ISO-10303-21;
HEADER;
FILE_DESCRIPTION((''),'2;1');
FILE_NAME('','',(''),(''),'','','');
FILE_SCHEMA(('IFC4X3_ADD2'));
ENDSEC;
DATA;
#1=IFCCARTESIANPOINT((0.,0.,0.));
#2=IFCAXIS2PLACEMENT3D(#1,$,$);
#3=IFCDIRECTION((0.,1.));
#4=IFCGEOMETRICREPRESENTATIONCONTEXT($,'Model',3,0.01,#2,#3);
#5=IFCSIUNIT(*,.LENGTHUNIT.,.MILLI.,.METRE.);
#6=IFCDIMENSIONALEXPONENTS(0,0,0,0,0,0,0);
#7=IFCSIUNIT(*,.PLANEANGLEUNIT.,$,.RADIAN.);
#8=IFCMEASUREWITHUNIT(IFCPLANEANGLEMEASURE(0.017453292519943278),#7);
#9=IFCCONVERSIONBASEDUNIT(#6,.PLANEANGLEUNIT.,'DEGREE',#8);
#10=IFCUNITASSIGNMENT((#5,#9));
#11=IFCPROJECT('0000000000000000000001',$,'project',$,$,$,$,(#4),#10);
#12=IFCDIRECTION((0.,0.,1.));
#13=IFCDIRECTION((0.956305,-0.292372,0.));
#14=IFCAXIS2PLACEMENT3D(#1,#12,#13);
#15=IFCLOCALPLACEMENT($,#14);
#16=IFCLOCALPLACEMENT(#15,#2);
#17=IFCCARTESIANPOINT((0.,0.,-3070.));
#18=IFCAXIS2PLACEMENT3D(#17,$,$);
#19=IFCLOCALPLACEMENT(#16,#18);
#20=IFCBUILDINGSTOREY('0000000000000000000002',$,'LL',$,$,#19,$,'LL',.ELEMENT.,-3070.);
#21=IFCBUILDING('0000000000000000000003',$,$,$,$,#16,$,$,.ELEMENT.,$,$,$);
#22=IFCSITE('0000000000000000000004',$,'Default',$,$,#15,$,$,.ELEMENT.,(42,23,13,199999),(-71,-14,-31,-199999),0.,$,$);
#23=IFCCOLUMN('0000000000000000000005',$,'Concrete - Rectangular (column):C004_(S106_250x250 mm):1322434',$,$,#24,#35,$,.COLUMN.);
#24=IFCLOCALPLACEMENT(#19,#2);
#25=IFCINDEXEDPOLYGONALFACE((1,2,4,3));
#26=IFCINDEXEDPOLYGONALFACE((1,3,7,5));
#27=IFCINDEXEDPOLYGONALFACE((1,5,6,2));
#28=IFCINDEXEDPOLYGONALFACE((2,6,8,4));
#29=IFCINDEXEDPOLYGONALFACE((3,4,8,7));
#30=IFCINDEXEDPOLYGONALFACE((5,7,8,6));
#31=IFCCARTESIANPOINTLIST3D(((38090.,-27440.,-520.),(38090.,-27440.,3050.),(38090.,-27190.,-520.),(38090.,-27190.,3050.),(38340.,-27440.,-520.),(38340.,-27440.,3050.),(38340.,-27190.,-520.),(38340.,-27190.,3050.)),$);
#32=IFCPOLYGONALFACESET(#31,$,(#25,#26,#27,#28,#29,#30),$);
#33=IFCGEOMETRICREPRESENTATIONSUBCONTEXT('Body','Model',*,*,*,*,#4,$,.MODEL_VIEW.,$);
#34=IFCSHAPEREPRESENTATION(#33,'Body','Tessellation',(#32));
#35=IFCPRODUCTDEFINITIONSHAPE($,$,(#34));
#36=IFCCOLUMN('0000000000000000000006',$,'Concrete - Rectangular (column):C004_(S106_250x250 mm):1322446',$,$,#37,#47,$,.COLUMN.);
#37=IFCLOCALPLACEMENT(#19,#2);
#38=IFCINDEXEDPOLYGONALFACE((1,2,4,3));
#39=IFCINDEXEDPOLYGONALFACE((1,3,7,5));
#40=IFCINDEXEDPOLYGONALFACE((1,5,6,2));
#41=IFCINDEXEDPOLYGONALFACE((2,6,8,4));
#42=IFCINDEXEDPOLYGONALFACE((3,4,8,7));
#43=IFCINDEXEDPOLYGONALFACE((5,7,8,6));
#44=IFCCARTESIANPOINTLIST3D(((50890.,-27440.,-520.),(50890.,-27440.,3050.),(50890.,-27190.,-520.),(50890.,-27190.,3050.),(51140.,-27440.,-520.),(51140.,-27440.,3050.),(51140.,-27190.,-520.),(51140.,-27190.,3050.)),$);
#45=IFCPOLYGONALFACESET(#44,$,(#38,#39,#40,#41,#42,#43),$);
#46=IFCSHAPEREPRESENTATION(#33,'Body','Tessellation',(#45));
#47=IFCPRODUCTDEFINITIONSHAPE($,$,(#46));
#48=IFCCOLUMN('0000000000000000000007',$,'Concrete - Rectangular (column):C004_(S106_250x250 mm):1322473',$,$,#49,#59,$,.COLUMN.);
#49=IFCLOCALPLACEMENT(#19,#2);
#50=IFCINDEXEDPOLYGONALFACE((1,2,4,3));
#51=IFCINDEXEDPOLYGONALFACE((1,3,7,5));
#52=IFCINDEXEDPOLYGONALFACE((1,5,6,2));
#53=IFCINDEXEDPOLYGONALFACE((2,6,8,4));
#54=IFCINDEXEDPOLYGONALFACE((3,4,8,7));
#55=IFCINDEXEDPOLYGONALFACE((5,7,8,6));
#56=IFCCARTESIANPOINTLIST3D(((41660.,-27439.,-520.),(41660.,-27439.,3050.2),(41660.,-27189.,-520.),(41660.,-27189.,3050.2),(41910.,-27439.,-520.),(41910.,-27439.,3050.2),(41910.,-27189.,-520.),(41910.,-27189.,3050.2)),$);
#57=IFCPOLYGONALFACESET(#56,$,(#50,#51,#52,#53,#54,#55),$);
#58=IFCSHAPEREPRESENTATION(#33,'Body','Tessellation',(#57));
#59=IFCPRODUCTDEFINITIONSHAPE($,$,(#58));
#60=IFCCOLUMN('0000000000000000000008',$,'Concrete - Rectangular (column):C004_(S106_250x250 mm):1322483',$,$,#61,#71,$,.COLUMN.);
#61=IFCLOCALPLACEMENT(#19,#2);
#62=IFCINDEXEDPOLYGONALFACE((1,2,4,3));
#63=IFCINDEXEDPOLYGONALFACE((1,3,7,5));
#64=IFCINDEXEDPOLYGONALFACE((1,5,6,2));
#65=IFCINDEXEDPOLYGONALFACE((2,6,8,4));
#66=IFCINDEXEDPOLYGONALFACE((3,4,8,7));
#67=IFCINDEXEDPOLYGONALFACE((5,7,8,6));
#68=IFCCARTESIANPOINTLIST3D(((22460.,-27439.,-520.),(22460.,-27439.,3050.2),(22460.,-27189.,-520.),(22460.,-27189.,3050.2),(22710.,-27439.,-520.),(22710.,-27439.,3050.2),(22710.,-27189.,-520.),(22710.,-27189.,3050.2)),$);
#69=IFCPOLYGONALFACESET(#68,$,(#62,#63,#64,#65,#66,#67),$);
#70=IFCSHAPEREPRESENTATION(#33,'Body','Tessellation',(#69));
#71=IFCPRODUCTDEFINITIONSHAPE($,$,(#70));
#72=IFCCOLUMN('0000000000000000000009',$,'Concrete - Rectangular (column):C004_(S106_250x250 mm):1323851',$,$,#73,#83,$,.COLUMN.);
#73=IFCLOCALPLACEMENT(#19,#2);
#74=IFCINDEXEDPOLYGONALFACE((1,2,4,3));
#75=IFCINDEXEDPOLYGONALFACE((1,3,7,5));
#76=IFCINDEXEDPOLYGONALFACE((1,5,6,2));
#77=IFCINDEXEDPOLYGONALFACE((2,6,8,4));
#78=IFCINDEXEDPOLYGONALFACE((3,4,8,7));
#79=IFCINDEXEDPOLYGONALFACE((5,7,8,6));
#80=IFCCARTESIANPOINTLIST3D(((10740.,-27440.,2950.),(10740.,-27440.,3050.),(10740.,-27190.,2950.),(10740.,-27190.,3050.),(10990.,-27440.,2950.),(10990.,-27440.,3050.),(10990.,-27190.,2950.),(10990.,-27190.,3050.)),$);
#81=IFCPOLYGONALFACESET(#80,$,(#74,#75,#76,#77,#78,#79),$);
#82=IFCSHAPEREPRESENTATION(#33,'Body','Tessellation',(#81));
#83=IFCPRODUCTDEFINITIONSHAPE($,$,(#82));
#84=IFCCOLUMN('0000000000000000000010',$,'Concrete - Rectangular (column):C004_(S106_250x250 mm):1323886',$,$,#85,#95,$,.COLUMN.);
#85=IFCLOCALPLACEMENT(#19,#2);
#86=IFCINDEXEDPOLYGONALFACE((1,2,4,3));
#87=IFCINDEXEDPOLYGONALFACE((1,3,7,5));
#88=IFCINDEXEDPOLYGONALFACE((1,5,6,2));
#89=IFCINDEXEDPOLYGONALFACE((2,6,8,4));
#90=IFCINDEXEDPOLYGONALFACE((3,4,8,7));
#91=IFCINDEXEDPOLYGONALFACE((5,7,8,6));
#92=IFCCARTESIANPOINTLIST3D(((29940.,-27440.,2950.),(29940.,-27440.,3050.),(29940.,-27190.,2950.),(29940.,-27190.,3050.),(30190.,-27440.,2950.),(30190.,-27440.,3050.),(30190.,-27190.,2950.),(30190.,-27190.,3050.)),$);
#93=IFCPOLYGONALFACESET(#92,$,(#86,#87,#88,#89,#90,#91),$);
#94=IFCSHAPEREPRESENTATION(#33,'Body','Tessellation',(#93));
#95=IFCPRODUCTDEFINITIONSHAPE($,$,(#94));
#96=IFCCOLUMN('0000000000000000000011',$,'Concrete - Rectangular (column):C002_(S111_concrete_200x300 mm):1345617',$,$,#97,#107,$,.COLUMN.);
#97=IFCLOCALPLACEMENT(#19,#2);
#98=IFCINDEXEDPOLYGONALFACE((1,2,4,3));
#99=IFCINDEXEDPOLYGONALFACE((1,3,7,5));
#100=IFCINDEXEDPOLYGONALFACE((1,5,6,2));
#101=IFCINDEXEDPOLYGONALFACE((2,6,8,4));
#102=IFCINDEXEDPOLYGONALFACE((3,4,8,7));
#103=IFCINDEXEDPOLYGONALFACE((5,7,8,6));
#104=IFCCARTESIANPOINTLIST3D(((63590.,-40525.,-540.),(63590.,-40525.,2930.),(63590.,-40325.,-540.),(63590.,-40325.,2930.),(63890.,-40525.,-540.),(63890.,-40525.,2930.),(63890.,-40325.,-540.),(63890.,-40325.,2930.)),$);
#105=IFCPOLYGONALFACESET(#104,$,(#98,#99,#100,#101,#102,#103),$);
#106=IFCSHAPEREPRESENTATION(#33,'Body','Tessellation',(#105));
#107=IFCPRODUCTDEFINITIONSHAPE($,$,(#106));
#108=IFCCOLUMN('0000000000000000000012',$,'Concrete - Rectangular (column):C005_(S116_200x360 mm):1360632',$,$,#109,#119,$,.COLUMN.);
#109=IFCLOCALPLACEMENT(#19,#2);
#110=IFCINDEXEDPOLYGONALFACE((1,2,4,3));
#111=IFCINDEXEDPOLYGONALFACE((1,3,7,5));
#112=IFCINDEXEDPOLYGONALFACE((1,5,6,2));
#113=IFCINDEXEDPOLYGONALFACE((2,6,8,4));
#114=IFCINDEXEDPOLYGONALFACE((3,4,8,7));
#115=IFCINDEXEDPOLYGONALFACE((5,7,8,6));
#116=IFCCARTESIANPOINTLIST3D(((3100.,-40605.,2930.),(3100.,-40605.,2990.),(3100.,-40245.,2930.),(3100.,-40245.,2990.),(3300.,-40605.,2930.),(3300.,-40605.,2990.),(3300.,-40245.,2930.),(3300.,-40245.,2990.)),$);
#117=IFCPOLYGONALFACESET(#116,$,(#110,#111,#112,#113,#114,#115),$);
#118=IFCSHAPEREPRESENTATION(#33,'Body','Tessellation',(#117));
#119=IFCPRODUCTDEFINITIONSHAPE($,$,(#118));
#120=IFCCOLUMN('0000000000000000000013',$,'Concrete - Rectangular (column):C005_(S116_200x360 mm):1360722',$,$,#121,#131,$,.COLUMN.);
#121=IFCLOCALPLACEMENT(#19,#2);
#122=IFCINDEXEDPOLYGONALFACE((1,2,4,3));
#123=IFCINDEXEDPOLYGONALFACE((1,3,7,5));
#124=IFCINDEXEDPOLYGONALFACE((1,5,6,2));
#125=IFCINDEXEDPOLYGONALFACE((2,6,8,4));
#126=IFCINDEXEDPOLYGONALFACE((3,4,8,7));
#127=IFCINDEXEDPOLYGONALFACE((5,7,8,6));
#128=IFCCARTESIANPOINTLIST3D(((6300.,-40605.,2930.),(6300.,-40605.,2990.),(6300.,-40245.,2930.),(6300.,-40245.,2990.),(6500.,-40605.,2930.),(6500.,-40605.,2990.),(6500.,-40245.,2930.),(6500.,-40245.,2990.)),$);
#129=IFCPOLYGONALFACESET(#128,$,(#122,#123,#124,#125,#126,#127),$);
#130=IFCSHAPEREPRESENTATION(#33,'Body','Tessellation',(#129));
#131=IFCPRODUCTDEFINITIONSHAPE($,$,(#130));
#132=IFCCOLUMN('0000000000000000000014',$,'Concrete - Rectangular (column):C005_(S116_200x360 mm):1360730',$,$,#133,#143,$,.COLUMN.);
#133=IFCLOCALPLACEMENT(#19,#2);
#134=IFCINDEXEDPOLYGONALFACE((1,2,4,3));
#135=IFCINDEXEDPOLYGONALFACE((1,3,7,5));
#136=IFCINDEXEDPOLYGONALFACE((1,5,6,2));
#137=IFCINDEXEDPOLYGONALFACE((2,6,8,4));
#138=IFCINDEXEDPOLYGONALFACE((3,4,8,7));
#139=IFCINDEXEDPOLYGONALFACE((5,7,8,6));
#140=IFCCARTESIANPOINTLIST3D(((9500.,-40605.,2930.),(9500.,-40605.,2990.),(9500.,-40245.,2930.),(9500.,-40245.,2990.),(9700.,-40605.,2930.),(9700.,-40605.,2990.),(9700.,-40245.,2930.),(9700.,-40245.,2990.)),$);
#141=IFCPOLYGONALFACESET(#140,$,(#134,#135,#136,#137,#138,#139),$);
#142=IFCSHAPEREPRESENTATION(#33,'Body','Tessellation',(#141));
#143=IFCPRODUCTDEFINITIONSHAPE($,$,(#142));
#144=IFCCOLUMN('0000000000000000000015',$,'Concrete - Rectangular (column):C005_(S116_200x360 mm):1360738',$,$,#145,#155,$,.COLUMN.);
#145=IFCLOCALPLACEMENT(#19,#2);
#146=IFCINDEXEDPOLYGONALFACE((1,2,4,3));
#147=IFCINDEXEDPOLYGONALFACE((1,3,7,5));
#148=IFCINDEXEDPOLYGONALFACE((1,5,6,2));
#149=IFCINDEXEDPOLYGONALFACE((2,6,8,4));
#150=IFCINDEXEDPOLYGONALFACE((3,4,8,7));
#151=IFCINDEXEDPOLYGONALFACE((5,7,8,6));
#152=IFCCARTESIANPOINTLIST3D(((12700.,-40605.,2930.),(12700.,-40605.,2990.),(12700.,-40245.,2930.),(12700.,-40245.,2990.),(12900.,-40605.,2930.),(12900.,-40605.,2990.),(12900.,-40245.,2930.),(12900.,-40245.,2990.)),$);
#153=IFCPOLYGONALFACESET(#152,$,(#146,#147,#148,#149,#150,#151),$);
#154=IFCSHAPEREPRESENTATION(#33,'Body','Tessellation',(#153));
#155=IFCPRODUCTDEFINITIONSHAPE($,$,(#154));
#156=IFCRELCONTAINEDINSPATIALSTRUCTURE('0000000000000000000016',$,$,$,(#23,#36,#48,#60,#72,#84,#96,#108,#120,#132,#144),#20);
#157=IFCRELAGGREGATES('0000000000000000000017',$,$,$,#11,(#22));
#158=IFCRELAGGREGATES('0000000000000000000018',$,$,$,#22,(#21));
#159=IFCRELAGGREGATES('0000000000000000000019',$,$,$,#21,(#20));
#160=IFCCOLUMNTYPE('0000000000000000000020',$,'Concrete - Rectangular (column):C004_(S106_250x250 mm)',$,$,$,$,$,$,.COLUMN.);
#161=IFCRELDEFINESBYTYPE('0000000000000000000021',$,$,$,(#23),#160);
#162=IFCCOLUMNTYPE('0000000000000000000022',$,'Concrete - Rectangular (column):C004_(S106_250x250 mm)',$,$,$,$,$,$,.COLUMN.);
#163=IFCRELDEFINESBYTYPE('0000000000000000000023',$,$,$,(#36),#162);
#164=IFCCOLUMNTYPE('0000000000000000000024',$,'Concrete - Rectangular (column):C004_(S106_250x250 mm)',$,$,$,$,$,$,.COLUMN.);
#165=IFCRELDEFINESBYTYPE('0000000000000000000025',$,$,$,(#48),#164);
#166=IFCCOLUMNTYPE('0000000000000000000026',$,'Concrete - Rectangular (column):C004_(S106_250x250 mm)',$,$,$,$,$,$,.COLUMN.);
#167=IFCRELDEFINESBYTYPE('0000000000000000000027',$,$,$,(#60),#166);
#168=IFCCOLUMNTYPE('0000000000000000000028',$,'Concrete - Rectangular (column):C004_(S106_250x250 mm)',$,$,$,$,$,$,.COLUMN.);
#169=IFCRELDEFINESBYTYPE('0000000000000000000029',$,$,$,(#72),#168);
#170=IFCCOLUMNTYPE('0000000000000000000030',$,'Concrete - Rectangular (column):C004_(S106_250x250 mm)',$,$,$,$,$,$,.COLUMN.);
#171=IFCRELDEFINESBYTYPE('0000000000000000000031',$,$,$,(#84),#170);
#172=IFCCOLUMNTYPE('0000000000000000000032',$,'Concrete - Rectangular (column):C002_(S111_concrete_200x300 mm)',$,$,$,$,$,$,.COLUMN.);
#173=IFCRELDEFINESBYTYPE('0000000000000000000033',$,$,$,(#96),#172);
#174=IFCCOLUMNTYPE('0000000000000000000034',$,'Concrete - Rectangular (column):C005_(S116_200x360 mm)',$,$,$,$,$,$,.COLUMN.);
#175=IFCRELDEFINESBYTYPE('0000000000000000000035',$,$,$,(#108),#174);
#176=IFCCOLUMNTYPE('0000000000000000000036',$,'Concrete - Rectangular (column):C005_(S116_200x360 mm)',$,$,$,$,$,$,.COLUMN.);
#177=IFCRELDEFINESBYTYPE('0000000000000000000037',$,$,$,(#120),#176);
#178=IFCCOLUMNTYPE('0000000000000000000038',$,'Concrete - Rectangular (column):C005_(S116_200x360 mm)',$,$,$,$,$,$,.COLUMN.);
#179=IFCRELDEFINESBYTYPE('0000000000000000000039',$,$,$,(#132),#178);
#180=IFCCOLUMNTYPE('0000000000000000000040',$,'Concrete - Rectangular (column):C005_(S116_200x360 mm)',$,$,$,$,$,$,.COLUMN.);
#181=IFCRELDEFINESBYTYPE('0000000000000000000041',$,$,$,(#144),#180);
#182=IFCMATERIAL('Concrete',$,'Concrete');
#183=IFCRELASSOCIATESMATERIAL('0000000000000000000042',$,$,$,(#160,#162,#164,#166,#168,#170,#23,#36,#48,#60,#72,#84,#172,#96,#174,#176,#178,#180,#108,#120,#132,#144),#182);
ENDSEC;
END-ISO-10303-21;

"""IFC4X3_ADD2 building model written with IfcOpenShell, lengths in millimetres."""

from ifc_helpers import new_model, entity, si_unit, converted_unit, direction, frame, frame_2d, origin, place, context, subcontext, project, spatial, rectangle, extrude, source, transform, mapped, material, material_profile, profile_set, profile_usage, type_object, type_shapes, element, save


model = new_model("IFC4X3_ADD2")

# Units and contexts
model_context = context("Model", 3, precision=0.01, world=origin(), true_north=direction((0.0, 1.0)))
body_context = subcontext(model_context, "Body", "Model", "MODEL_VIEW")
ifc_project = project(units=[si_unit("LENGTHUNIT", "METRE", prefix="MILLI"), converted_unit("PLANEANGLEUNIT", "DEGREE", entity("IfcPlaneAngleMeasure", 0.017453292519943278), si_unit("PLANEANGLEUNIT", "RADIAN"), dimensions=[0, 0, 0, 0, 0, 0, 0])], contexts=[model_context])

# Site, building, storey
site_placement = place(None, frame((0.0, 0.0, 0.0), z_axis=(0.0, 0.0, 1.0), x_axis=(0.956305, -0.292372, 0.0)))
site = spatial("IfcSite", under=ifc_project, at=site_placement, Name="Default", CompositionType="ELEMENT", RefLatitude=(42, 23, 13, 199999), RefLongitude=(-71, -14, -31, -199999), RefElevation=0.0)
building_placement = place(site_placement, origin())
building = spatial("IfcBuilding", under=site, at=building_placement, CompositionType="ELEMENT")
storey_placement = place(building_placement, frame((0.0, 0.0, -3070.0)))
storey = spatial("IfcBuildingStorey", under=building, at=storey_placement, Name="LL", LongName="LL", CompositionType="ELEMENT", Elevation=-3070.0)

# Columns
ifc_material_1 = material(Name="Concrete", Category="Concrete")
ifc_material_profile_1 = material_profile(ifc_material_1, rectangle(XDim=300.0, YDim=200.0, at=frame_2d((0.0, 0.0), x_axis=(1.0, 0.0))), Name="C002_(S111_concrete_200x300 mm)")
ifc_profile_set_1 = profile_set([ifc_material_profile_1], Name="C002_(S111_concrete_200x300 mm)")
ifc_profile_usage_1 = profile_usage(ifc_profile_set_1)
ifc_material_profile_2 = material_profile(ifc_material_1, rectangle(XDim=250.0, YDim=250.0, at=frame_2d((0.0, 0.0), x_axis=(1.0, 0.0))), Name="C004_(S106_250x250 mm)")
ifc_profile_set_2 = profile_set([ifc_material_profile_2], Name="C004_(S106_250x250 mm)")
ifc_profile_usage_2 = profile_usage(ifc_profile_set_2)
column_type_1 = type_object("IfcColumnType", Name="Concrete - Rectangular (column):C004_(S106_250x250 mm)", PredefinedType="COLUMN", material=ifc_profile_set_2)
shared_shape_1 = source(origin(), body_context, "Body", "SweptSolid", [
    extrude(rectangle(XDim=250.0, YDim=250.0, at=frame_2d((0.0, 0.0), x_axis=(1.0, 0.0))), frame((38215.0, -27315.0, -3590.0), z_axis=(0.0, 0.0, 1.0), x_axis=(-1.0, 0.0, 0.0)), (0.0, 0.0, 1.0), 3570.0),
])
type_shapes(column_type_1, [shared_shape_1])
column_1_placement = place(storey_placement, frame((0.0, 0.0, 3070.0)))
element("IfcColumn", 1, at=column_1_placement, inside=storey, type_object=column_type_1, material=ifc_profile_usage_2, Name="Concrete - Rectangular (column):C004_(S106_250x250 mm):1322434", PredefinedType="COLUMN", context=body_context, shape_type="MappedRepresentation", body=[
    mapped(shared_shape_1, transform((0.0, 0.0, 0.0), scale=1.0)),
])
column_type_2 = type_object("IfcColumnType", Name="Concrete - Rectangular (column):C004_(S106_250x250 mm)", PredefinedType="COLUMN", material=ifc_profile_set_2)
shared_shape_2 = source(origin(), body_context, "Body", "SweptSolid", [
    extrude(rectangle(XDim=250.0, YDim=250.0, at=frame_2d((0.0, 0.0), x_axis=(1.0, 0.0))), frame((51015.0, -27315.0, -3590.0), z_axis=(0.0, 0.0, 1.0), x_axis=(-1.0, 0.0, 0.0)), (0.0, 0.0, 1.0), 3570.0),
])
type_shapes(column_type_2, [shared_shape_2])
column_2_placement = place(storey_placement, frame((0.0, 0.0, 3070.0)))
element("IfcColumn", 2, at=column_2_placement, inside=storey, type_object=column_type_2, material=ifc_profile_usage_2, Name="Concrete - Rectangular (column):C004_(S106_250x250 mm):1322446", PredefinedType="COLUMN", context=body_context, shape_type="MappedRepresentation", body=[
    mapped(shared_shape_2, transform((0.0, 0.0, 0.0), scale=1.0)),
])
column_type_3 = type_object("IfcColumnType", Name="Concrete - Rectangular (column):C004_(S106_250x250 mm)", PredefinedType="COLUMN", material=ifc_profile_set_2)
shared_shape_3 = source(origin(), body_context, "Body", "SweptSolid", [
    extrude(rectangle(XDim=250.0, YDim=250.0, at=frame_2d((0.0, 0.0), x_axis=(1.0, 0.0))), frame((41785.0, -27314.0, -3590.0), z_axis=(0.0, 0.0, 1.0), x_axis=(-1.0, 0.0, 0.0)), (0.0, 0.0, 1.0), 3570.2),
])
type_shapes(column_type_3, [shared_shape_3])
column_3_placement = place(storey_placement, frame((0.0, 0.0, 3070.0)))
element("IfcColumn", 3, at=column_3_placement, inside=storey, type_object=column_type_3, material=ifc_profile_usage_2, Name="Concrete - Rectangular (column):C004_(S106_250x250 mm):1322473", PredefinedType="COLUMN", context=body_context, shape_type="MappedRepresentation", body=[
    mapped(shared_shape_3, transform((0.0, 0.0, 0.0), scale=1.0)),
])
column_type_4 = type_object("IfcColumnType", Name="Concrete - Rectangular (column):C004_(S106_250x250 mm)", PredefinedType="COLUMN", material=ifc_profile_set_2)
shared_shape_4 = source(origin(), body_context, "Body", "SweptSolid", [
    extrude(rectangle(XDim=250.0, YDim=250.0, at=frame_2d((0.0, 0.0), x_axis=(1.0, 0.0))), frame((22585.0, -27314.0, -3590.0), z_axis=(0.0, 0.0, 1.0), x_axis=(-1.0, 0.0, 0.0)), (0.0, 0.0, 1.0), 3570.2),
])
type_shapes(column_type_4, [shared_shape_4])
column_4_placement = place(storey_placement, frame((0.0, 0.0, 3070.0)))
element("IfcColumn", 4, at=column_4_placement, inside=storey, type_object=column_type_4, material=ifc_profile_usage_2, Name="Concrete - Rectangular (column):C004_(S106_250x250 mm):1322483", PredefinedType="COLUMN", context=body_context, shape_type="MappedRepresentation", body=[
    mapped(shared_shape_4, transform((0.0, 0.0, 0.0), scale=1.0)),
])
column_type_5 = type_object("IfcColumnType", Name="Concrete - Rectangular (column):C004_(S106_250x250 mm)", PredefinedType="COLUMN", material=ifc_profile_set_2)
shared_shape_5 = source(origin(), body_context, "Body", "SweptSolid", [
    extrude(rectangle(XDim=250.0, YDim=250.0, at=frame_2d((0.0, 0.0), x_axis=(1.0, 0.0))), frame((10865.0, -27315.0, -120.0), z_axis=(0.0, 0.0, 1.0), x_axis=(-1.0, 0.0, 0.0)), (0.0, 0.0, 1.0), 100.0),
])
type_shapes(column_type_5, [shared_shape_5])
column_5_placement = place(storey_placement, frame((0.0, 0.0, 3070.0)))
element("IfcColumn", 5, at=column_5_placement, inside=storey, type_object=column_type_5, material=ifc_profile_usage_2, Name="Concrete - Rectangular (column):C004_(S106_250x250 mm):1323851", PredefinedType="COLUMN", context=body_context, shape_type="MappedRepresentation", body=[
    mapped(shared_shape_5, transform((0.0, 0.0, 0.0), scale=1.0)),
])
column_type_6 = type_object("IfcColumnType", Name="Concrete - Rectangular (column):C004_(S106_250x250 mm)", PredefinedType="COLUMN", material=ifc_profile_set_2)
shared_shape_6 = source(origin(), body_context, "Body", "SweptSolid", [
    extrude(rectangle(XDim=250.0, YDim=250.0, at=frame_2d((0.0, 0.0), x_axis=(1.0, 0.0))), frame((30065.0, -27315.0, -120.0), z_axis=(0.0, 0.0, 1.0), x_axis=(-1.0, 0.0, 0.0)), (0.0, 0.0, 1.0), 100.0),
])
type_shapes(column_type_6, [shared_shape_6])
column_6_placement = place(storey_placement, frame((0.0, 0.0, 3070.0)))
element("IfcColumn", 6, at=column_6_placement, inside=storey, type_object=column_type_6, material=ifc_profile_usage_2, Name="Concrete - Rectangular (column):C004_(S106_250x250 mm):1323886", PredefinedType="COLUMN", context=body_context, shape_type="MappedRepresentation", body=[
    mapped(shared_shape_6, transform((0.0, 0.0, 0.0), scale=1.0)),
])
column_type_7 = type_object("IfcColumnType", Name="Concrete - Rectangular (column):C002_(S111_concrete_200x300 mm)", PredefinedType="COLUMN", material=ifc_profile_set_1)
shared_shape_7 = source(origin(), body_context, "Body", "SweptSolid", [
    extrude(rectangle(XDim=300.0, YDim=200.0, at=frame_2d((0.0, 0.0), x_axis=(1.0, 0.0))), frame((63740.0, -40425.0, -3610.0), z_axis=(0.0, 0.0, 1.0), x_axis=(-1.0, 0.0, 0.0)), (0.0, 0.0, 1.0), 3470.0),
])
type_shapes(column_type_7, [shared_shape_7])
column_7_placement = place(storey_placement, frame((0.0, 0.0, 3070.0)))
element("IfcColumn", 7, at=column_7_placement, inside=storey, type_object=column_type_7, material=ifc_profile_usage_1, Name="Concrete - Rectangular (column):C002_(S111_concrete_200x300 mm):1345617", PredefinedType="COLUMN", context=body_context, shape_type="MappedRepresentation", body=[
    mapped(shared_shape_7, transform((0.0, 0.0, 0.0), scale=1.0)),
])
ifc_material_profile_3 = material_profile(ifc_material_1, rectangle(XDim=200.0, YDim=360.0, at=frame_2d((0.0, 0.0), x_axis=(1.0, 0.0))), Name="C005_(S116_200x360 mm)")
ifc_profile_set_3 = profile_set([ifc_material_profile_3], Name="C005_(S116_200x360 mm)")
ifc_profile_usage_3 = profile_usage(ifc_profile_set_3)
column_type_8 = type_object("IfcColumnType", Name="Concrete - Rectangular (column):C005_(S116_200x360 mm)", PredefinedType="COLUMN", material=ifc_profile_set_3)
shared_shape_8 = source(origin(), body_context, "Body", "SweptSolid", [
    extrude(rectangle(XDim=200.0, YDim=360.0, at=frame_2d((0.0, 0.0), x_axis=(1.0, 0.0))), frame((3200.0, -40425.0, -140.0), z_axis=(0.0, 0.0, 1.0), x_axis=(-1.0, 0.0, 0.0)), (0.0, 0.0, 1.0), 60.0),
])
type_shapes(column_type_8, [shared_shape_8])
column_8_placement = place(storey_placement, frame((0.0, 0.0, 3070.0)))
element("IfcColumn", 8, at=column_8_placement, inside=storey, type_object=column_type_8, material=ifc_profile_usage_3, Name="Concrete - Rectangular (column):C005_(S116_200x360 mm):1360632", PredefinedType="COLUMN", context=body_context, shape_type="MappedRepresentation", body=[
    mapped(shared_shape_8, transform((0.0, 0.0, 0.0), scale=1.0)),
])
column_type_9 = type_object("IfcColumnType", Name="Concrete - Rectangular (column):C005_(S116_200x360 mm)", PredefinedType="COLUMN", material=ifc_profile_set_3)
shared_shape_9 = source(origin(), body_context, "Body", "SweptSolid", [
    extrude(rectangle(XDim=200.0, YDim=360.0, at=frame_2d((0.0, 0.0), x_axis=(1.0, 0.0))), frame((6400.0, -40425.0, -140.0), z_axis=(0.0, 0.0, 1.0), x_axis=(-1.0, 0.0, 0.0)), (0.0, 0.0, 1.0), 60.0),
])
type_shapes(column_type_9, [shared_shape_9])
column_9_placement = place(storey_placement, frame((0.0, 0.0, 3070.0)))
element("IfcColumn", 9, at=column_9_placement, inside=storey, type_object=column_type_9, material=ifc_profile_usage_3, Name="Concrete - Rectangular (column):C005_(S116_200x360 mm):1360722", PredefinedType="COLUMN", context=body_context, shape_type="MappedRepresentation", body=[
    mapped(shared_shape_9, transform((0.0, 0.0, 0.0), scale=1.0)),
])
column_type_10 = type_object("IfcColumnType", Name="Concrete - Rectangular (column):C005_(S116_200x360 mm)", PredefinedType="COLUMN", material=ifc_profile_set_3)
shared_shape_10 = source(origin(), body_context, "Body", "SweptSolid", [
    extrude(rectangle(XDim=200.0, YDim=360.0, at=frame_2d((0.0, 0.0), x_axis=(1.0, 0.0))), frame((9600.0, -40425.0, -140.0), z_axis=(0.0, 0.0, 1.0), x_axis=(-1.0, 0.0, 0.0)), (0.0, 0.0, 1.0), 60.0),
])
type_shapes(column_type_10, [shared_shape_10])
column_10_placement = place(storey_placement, frame((0.0, 0.0, 3070.0)))
element("IfcColumn", 10, at=column_10_placement, inside=storey, type_object=column_type_10, material=ifc_profile_usage_3, Name="Concrete - Rectangular (column):C005_(S116_200x360 mm):1360730", PredefinedType="COLUMN", context=body_context, shape_type="MappedRepresentation", body=[
    mapped(shared_shape_10, transform((0.0, 0.0, 0.0), scale=1.0)),
])
column_type_11 = type_object("IfcColumnType", Name="Concrete - Rectangular (column):C005_(S116_200x360 mm)", PredefinedType="COLUMN", material=ifc_profile_set_3)
shared_shape_11 = source(origin(), body_context, "Body", "SweptSolid", [
    extrude(rectangle(XDim=200.0, YDim=360.0, at=frame_2d((0.0, 0.0), x_axis=(1.0, 0.0))), frame((12800.0, -40425.0, -140.0), z_axis=(0.0, 0.0, 1.0), x_axis=(-1.0, 0.0, 0.0)), (0.0, 0.0, 1.0), 60.0),
])
type_shapes(column_type_11, [shared_shape_11])
column_11_placement = place(storey_placement, frame((0.0, 0.0, 3070.0)))
element("IfcColumn", 11, at=column_11_placement, inside=storey, type_object=column_type_11, material=ifc_profile_usage_3, Name="Concrete - Rectangular (column):C005_(S116_200x360 mm):1360738", PredefinedType="COLUMN", context=body_context, shape_type="MappedRepresentation", body=[
    mapped(shared_shape_11, transform((0.0, 0.0, 0.0), scale=1.0)),
])

save(model, "model.ifc")
